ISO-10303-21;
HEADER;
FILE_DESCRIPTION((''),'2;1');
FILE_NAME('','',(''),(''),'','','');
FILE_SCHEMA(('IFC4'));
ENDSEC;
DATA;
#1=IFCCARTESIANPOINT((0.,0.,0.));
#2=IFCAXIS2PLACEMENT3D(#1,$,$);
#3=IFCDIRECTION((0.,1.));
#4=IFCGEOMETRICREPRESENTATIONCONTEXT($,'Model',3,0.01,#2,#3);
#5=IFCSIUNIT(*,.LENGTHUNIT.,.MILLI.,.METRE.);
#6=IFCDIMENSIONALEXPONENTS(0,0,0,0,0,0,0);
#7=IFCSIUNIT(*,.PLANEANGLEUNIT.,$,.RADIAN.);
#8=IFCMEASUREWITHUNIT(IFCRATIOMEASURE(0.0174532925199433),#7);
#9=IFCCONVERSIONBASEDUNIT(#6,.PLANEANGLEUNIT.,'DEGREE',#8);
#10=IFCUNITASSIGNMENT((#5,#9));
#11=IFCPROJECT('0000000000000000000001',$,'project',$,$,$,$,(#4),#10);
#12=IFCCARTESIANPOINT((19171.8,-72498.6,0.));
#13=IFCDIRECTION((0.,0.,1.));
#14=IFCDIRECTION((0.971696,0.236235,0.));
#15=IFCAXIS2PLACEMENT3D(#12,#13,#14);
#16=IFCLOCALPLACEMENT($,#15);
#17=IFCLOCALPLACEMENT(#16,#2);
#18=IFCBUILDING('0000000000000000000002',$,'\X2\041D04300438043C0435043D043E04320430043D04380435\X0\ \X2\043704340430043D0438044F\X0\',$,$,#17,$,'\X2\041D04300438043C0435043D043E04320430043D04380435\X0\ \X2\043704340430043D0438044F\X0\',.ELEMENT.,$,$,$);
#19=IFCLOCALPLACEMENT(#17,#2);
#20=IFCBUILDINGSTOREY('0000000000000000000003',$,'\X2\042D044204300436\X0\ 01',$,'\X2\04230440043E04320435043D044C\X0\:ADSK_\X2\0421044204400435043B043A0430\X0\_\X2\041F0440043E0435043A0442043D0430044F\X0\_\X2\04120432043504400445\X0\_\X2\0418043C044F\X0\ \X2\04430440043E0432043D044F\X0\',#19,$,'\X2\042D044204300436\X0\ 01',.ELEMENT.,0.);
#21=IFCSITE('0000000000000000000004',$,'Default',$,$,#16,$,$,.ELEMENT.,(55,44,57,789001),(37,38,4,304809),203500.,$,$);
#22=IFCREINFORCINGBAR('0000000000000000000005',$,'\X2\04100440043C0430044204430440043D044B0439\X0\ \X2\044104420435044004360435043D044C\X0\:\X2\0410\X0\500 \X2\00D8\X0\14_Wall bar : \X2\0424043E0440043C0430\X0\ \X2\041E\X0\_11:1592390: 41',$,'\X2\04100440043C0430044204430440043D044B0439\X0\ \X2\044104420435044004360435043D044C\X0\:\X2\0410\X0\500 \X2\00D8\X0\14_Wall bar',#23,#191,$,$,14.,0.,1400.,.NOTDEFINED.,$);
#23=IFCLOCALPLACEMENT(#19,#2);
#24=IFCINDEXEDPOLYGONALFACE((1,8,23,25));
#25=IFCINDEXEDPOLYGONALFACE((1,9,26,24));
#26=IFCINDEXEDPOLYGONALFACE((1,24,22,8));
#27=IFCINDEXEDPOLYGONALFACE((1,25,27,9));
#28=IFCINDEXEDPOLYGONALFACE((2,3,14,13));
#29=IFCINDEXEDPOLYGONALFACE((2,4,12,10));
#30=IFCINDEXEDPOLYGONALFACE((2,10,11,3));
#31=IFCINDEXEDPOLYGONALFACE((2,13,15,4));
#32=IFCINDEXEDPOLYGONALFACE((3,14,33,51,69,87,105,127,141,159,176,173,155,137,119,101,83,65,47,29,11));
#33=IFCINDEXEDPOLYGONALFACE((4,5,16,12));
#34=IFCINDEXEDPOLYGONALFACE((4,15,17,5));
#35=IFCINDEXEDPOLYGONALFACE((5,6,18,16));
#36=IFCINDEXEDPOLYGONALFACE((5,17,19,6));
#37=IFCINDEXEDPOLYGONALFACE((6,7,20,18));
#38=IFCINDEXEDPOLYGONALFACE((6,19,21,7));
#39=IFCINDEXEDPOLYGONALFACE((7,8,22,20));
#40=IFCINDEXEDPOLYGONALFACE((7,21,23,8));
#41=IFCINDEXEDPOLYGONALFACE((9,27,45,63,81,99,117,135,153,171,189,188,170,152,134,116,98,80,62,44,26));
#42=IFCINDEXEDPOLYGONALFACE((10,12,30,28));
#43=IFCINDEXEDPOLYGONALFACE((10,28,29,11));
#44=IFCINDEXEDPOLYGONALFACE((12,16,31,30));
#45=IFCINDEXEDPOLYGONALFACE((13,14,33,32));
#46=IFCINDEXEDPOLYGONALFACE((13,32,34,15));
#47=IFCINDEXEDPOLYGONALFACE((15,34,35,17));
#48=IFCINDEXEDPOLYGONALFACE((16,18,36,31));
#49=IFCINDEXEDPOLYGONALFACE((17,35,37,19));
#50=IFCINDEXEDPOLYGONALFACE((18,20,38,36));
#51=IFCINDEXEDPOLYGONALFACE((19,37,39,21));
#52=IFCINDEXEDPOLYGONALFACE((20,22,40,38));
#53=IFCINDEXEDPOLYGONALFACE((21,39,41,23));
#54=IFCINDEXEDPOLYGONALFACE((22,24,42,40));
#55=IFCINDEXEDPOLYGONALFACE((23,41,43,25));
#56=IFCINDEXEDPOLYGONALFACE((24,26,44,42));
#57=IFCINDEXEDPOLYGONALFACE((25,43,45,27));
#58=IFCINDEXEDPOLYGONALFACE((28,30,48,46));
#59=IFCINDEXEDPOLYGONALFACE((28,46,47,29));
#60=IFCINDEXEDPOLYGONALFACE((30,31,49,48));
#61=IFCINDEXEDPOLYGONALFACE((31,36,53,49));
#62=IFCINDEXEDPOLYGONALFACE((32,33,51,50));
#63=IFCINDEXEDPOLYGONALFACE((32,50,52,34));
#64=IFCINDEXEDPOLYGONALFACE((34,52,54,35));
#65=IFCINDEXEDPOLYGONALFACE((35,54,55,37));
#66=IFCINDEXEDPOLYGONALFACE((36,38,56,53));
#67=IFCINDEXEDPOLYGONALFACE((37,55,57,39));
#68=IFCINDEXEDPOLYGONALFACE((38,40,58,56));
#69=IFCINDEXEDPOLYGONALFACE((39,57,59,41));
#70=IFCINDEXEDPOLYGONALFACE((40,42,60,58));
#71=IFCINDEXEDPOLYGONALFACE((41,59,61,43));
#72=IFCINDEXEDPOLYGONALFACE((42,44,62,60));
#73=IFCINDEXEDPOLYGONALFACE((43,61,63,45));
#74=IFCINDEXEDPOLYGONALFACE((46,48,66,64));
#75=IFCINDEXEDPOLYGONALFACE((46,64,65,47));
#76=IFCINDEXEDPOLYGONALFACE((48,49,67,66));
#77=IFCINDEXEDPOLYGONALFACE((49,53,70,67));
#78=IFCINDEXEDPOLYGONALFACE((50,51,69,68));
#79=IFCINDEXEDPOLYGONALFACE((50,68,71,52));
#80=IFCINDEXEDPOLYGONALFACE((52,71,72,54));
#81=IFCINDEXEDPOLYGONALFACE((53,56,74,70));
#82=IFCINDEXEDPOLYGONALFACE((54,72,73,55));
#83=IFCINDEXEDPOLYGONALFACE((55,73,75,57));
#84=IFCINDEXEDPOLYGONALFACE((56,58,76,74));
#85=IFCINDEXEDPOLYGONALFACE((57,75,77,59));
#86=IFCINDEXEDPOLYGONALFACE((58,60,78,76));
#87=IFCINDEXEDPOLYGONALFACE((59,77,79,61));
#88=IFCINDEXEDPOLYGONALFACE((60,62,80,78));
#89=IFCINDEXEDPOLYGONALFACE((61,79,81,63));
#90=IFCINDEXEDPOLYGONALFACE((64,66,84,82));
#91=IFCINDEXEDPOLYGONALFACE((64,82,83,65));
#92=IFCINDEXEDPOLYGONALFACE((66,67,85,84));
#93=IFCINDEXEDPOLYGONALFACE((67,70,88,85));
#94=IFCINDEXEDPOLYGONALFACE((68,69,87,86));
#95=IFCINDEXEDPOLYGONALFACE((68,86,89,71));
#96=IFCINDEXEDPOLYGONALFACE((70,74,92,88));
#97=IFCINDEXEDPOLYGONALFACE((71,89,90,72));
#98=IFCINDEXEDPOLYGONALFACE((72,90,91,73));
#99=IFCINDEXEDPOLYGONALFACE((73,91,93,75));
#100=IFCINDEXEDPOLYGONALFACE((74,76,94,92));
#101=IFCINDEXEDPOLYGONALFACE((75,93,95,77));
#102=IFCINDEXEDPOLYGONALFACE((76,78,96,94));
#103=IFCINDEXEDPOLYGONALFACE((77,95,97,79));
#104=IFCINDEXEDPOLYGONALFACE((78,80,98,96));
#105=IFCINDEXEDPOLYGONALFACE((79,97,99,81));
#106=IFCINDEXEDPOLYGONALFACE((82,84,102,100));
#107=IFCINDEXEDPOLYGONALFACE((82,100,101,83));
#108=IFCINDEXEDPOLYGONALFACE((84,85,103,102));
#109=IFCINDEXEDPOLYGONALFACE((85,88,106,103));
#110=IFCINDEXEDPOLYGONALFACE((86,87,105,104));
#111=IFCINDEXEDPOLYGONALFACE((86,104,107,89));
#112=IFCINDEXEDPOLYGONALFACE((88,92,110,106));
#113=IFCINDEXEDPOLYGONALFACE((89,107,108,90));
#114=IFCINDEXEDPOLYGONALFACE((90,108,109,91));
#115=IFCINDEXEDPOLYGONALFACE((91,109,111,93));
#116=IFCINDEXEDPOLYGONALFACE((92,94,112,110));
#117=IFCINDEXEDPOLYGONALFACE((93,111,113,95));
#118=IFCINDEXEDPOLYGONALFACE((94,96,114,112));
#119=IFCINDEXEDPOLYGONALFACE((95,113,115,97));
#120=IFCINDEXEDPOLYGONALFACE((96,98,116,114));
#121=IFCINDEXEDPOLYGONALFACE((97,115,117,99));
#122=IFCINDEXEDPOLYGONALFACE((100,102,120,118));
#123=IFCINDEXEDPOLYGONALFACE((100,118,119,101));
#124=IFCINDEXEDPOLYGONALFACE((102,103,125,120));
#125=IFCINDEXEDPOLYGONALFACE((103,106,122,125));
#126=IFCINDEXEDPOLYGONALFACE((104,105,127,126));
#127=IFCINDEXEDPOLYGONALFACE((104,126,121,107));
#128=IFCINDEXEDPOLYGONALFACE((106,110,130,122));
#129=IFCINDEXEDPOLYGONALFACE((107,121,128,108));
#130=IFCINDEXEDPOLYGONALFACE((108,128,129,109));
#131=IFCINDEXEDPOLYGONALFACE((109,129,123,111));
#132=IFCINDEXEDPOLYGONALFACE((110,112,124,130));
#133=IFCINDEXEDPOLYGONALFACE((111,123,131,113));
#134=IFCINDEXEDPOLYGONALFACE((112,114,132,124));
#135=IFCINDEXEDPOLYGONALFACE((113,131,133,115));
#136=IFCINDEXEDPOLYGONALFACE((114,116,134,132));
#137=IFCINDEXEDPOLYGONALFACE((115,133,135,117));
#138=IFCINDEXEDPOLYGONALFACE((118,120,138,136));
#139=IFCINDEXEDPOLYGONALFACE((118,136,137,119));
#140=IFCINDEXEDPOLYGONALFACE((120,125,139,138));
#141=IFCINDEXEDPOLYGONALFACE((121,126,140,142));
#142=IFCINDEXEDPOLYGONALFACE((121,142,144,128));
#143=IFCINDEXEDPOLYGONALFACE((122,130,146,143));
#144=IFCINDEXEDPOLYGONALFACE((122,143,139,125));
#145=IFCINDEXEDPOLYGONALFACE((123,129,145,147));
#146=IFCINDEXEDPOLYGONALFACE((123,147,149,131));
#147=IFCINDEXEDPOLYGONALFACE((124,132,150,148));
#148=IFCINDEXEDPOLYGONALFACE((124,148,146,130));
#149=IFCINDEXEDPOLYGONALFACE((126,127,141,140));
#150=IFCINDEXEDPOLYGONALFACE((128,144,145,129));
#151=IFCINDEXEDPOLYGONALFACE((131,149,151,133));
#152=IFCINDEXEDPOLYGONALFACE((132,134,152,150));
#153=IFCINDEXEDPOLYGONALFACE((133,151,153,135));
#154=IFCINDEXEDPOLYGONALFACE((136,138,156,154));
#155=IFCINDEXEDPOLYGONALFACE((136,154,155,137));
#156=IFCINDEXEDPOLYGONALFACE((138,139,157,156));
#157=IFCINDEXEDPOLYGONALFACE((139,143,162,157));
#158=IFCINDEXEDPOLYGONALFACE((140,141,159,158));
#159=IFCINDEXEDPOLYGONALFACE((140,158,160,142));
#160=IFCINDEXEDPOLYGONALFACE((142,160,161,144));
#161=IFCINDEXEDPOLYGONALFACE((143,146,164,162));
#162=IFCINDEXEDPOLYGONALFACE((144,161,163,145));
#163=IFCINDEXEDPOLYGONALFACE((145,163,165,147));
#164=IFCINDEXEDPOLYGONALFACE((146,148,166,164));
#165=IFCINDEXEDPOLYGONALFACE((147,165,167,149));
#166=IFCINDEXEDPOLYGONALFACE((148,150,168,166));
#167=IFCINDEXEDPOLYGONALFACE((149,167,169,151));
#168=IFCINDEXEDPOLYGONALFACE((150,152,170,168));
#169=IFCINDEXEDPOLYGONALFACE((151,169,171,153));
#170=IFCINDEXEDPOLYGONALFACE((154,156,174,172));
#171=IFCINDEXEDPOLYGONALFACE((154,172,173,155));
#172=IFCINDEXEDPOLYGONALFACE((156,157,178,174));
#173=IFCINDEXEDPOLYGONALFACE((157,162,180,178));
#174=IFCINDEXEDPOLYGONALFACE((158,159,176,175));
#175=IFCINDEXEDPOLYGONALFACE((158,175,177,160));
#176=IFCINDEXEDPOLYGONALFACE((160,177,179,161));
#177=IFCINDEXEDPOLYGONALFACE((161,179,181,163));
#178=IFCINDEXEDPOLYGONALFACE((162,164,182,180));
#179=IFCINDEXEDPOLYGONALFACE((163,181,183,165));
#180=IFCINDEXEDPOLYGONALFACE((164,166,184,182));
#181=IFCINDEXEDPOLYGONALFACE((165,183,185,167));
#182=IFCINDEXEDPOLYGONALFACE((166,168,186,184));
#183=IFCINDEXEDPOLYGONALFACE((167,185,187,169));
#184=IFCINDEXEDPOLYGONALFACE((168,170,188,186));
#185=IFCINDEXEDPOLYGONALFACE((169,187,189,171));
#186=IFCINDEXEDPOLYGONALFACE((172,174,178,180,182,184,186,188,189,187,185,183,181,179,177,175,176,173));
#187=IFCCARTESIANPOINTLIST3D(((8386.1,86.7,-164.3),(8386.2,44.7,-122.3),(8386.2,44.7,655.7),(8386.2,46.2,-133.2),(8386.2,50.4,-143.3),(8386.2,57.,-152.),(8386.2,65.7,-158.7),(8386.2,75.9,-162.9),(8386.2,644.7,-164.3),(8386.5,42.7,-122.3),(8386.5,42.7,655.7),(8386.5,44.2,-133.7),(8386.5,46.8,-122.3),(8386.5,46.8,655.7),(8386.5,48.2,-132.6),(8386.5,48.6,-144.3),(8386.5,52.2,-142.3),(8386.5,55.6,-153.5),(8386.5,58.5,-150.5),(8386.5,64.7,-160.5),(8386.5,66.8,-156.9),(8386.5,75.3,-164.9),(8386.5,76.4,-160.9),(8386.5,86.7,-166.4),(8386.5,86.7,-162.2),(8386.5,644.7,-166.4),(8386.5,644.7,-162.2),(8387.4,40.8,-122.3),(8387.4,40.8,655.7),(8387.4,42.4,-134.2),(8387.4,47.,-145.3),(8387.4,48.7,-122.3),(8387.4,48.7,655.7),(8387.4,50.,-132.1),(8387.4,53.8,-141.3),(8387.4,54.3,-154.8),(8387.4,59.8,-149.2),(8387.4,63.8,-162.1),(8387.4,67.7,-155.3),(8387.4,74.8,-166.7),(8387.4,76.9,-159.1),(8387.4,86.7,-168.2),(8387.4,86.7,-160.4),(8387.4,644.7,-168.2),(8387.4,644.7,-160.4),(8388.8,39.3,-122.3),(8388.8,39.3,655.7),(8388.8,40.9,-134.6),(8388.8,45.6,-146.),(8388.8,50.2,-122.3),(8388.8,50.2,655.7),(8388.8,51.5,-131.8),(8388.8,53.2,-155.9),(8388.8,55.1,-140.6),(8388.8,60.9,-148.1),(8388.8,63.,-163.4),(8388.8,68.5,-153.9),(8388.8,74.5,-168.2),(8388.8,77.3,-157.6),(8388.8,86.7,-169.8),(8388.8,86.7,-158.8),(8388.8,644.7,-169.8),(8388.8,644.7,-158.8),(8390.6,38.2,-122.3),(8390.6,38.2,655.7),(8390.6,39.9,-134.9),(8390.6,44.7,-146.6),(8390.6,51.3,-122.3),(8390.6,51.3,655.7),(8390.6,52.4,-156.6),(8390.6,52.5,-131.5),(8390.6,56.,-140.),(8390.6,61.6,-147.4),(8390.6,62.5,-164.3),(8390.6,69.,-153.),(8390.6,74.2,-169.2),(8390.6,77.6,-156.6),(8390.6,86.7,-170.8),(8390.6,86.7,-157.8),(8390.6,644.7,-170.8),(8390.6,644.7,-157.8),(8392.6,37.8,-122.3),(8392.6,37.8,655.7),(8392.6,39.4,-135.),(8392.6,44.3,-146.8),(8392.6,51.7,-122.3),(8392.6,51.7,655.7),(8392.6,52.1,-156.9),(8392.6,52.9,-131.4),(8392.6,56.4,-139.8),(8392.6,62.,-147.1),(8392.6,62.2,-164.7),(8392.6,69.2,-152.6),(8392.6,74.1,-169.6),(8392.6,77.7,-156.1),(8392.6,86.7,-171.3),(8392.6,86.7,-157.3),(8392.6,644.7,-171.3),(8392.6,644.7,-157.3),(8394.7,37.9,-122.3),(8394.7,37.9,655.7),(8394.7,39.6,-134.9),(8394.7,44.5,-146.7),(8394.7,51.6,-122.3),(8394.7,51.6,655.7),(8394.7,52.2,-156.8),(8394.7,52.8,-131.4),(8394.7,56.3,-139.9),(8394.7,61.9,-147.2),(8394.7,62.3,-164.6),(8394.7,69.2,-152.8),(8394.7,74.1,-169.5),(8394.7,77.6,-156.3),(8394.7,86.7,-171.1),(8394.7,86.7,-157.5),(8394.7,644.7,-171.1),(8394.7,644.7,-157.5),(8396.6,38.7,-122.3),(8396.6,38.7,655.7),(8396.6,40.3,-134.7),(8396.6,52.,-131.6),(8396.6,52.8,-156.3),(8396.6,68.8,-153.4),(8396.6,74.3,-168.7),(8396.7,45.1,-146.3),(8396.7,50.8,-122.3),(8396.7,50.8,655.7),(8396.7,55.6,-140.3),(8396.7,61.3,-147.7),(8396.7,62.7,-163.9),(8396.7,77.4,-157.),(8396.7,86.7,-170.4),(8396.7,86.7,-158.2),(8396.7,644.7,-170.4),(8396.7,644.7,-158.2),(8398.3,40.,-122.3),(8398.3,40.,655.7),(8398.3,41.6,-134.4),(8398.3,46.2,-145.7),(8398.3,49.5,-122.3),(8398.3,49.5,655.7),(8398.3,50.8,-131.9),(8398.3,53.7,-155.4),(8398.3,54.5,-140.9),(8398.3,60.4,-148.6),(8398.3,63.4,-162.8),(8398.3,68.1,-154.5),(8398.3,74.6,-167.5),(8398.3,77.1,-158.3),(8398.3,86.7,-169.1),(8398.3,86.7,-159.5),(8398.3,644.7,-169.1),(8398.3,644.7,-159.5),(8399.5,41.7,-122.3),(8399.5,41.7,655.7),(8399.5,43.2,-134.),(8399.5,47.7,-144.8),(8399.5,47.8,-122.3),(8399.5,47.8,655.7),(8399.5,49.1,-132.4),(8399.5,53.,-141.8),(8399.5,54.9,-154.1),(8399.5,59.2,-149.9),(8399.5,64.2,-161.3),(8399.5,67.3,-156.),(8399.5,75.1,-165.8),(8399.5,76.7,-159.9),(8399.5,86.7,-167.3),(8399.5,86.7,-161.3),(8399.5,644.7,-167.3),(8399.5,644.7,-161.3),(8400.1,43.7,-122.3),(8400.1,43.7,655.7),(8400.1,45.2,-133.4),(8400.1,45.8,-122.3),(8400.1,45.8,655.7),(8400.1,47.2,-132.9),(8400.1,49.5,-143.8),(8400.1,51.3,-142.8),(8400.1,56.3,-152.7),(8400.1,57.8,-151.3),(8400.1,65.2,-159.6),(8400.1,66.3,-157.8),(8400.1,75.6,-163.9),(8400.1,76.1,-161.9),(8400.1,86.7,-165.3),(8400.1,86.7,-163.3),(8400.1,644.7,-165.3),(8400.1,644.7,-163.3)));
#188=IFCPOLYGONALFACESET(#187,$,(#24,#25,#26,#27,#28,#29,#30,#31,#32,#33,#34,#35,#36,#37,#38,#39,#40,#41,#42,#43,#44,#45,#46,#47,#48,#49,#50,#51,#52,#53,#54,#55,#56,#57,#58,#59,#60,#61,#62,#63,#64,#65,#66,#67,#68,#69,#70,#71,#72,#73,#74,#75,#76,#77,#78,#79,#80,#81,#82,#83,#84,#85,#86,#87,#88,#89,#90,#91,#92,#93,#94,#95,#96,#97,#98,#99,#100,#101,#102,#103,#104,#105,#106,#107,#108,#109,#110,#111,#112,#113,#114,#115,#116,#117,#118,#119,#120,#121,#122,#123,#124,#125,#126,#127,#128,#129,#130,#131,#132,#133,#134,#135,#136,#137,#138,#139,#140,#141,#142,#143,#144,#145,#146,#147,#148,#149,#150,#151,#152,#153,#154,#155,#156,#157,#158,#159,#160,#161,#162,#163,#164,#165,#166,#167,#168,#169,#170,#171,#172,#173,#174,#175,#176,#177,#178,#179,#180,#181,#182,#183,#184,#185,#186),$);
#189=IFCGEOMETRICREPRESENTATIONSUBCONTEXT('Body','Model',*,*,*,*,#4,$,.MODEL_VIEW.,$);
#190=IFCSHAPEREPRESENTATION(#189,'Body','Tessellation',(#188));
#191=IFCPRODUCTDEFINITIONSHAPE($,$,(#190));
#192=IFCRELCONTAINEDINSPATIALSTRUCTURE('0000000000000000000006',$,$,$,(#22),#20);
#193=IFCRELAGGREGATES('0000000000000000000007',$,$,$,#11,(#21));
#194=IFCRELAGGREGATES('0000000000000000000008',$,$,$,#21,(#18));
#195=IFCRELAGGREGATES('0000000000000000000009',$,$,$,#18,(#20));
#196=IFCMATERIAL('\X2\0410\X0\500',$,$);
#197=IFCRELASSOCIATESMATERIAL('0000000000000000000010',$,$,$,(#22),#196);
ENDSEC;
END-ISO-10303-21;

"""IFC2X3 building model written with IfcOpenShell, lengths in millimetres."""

from ifc_helpers import new_model, entity, si_unit, converted_unit, direction, frame, origin, place, context, subcontext, project, spatial, material, element, save


model = new_model("IFC2X3")

# Units and contexts
model_context = context("Model", 3, precision=0.01, world=origin(), true_north=direction((0.0, 1.0)))
body_context = subcontext(model_context, "Body", "Model", "MODEL_VIEW")
ifc_project = project(units=[si_unit("LENGTHUNIT", "METRE", prefix="MILLI"), converted_unit("PLANEANGLEUNIT", "DEGREE", entity("IfcRatioMeasure", 0.0174532925199433), si_unit("PLANEANGLEUNIT", "RADIAN"), dimensions=[0, 0, 0, 0, 0, 0, 0])], contexts=[model_context])

# Site, building, storey
site_placement = place(None, frame((19171.8, -72498.6, 0.0), z_axis=(0.0, 0.0, 1.0), x_axis=(0.971696, 0.236235, 0.0)))
site = spatial("IfcSite", under=ifc_project, at=site_placement, Name="Default", CompositionType="ELEMENT", RefLatitude=(55, 44, 57, 789001), RefLongitude=(37, 38, 4, 304809), RefElevation=203500.0)
building_placement = place(site_placement, origin())
building = spatial("IfcBuilding", under=site, at=building_placement, Name="Наименование здания", LongName="Наименование здания", CompositionType="ELEMENT")
storey_placement = place(building_placement, origin())
storey = spatial("IfcBuildingStorey", under=building, at=storey_placement, Name="Этаж 01", ObjectType="Уровень:ADSK_Стрелка_Проектная_Вверх_Имя уровня", LongName="Этаж 01", CompositionType="ELEMENT", Elevation=0.0)

# Reinforcing bar
ifc_material = material(Name="А500")
placement = place(storey_placement, origin())
element("IfcReinforcingBar", 1, at=placement, inside=storey, material=ifc_material, Name="Арматурный стержень:А500 Ø14_Wall bar : Форма О_11:1592390: 41", ObjectType="Арматурный стержень:А500 Ø14_Wall bar", BarLength=1400.0, BarRole="NOTDEFINED", CrossSectionArea=0.0, NominalDiameter=14.0, context=body_context, shape_type="AdvancedSweptSolid", body=[
    entity("IfcSweptDiskSolid", entity("IfcCompositeCurve", [entity("IfcCompositeCurveSegment", "CONTINUOUS", True, entity("IfcPolyline", [entity("IfcCartesianPoint", [8393.1, 44.7, 655.7]), entity("IfcCartesianPoint", [8393.1, 44.7, -122.3])])), entity("IfcCompositeCurveSegment", "CONTINUOUS", True, entity("IfcTrimmedCurve", entity("IfcCircle", entity("IfcAxis2Placement3D", entity("IfcCartesianPoint", [8393.1, 86.7, -122.3]), entity("IfcDirection", [1.0, 0.0, 0.0]), entity("IfcDirection", [0.0, 0.0, -1.0])), 42.0), [entity("IfcParameterValue", 270.0)], [entity("IfcParameterValue", 360.0)], True, "PARAMETER")), entity("IfcCompositeCurveSegment", "CONTINUOUS", True, entity("IfcPolyline", [entity("IfcCartesianPoint", [8393.1, 86.7, -164.3]), entity("IfcCartesianPoint", [8393.1, 644.7, -164.3])]))], False), 7.0, None, 0.0, 92.0),
])

save(model, "model.ifc")
